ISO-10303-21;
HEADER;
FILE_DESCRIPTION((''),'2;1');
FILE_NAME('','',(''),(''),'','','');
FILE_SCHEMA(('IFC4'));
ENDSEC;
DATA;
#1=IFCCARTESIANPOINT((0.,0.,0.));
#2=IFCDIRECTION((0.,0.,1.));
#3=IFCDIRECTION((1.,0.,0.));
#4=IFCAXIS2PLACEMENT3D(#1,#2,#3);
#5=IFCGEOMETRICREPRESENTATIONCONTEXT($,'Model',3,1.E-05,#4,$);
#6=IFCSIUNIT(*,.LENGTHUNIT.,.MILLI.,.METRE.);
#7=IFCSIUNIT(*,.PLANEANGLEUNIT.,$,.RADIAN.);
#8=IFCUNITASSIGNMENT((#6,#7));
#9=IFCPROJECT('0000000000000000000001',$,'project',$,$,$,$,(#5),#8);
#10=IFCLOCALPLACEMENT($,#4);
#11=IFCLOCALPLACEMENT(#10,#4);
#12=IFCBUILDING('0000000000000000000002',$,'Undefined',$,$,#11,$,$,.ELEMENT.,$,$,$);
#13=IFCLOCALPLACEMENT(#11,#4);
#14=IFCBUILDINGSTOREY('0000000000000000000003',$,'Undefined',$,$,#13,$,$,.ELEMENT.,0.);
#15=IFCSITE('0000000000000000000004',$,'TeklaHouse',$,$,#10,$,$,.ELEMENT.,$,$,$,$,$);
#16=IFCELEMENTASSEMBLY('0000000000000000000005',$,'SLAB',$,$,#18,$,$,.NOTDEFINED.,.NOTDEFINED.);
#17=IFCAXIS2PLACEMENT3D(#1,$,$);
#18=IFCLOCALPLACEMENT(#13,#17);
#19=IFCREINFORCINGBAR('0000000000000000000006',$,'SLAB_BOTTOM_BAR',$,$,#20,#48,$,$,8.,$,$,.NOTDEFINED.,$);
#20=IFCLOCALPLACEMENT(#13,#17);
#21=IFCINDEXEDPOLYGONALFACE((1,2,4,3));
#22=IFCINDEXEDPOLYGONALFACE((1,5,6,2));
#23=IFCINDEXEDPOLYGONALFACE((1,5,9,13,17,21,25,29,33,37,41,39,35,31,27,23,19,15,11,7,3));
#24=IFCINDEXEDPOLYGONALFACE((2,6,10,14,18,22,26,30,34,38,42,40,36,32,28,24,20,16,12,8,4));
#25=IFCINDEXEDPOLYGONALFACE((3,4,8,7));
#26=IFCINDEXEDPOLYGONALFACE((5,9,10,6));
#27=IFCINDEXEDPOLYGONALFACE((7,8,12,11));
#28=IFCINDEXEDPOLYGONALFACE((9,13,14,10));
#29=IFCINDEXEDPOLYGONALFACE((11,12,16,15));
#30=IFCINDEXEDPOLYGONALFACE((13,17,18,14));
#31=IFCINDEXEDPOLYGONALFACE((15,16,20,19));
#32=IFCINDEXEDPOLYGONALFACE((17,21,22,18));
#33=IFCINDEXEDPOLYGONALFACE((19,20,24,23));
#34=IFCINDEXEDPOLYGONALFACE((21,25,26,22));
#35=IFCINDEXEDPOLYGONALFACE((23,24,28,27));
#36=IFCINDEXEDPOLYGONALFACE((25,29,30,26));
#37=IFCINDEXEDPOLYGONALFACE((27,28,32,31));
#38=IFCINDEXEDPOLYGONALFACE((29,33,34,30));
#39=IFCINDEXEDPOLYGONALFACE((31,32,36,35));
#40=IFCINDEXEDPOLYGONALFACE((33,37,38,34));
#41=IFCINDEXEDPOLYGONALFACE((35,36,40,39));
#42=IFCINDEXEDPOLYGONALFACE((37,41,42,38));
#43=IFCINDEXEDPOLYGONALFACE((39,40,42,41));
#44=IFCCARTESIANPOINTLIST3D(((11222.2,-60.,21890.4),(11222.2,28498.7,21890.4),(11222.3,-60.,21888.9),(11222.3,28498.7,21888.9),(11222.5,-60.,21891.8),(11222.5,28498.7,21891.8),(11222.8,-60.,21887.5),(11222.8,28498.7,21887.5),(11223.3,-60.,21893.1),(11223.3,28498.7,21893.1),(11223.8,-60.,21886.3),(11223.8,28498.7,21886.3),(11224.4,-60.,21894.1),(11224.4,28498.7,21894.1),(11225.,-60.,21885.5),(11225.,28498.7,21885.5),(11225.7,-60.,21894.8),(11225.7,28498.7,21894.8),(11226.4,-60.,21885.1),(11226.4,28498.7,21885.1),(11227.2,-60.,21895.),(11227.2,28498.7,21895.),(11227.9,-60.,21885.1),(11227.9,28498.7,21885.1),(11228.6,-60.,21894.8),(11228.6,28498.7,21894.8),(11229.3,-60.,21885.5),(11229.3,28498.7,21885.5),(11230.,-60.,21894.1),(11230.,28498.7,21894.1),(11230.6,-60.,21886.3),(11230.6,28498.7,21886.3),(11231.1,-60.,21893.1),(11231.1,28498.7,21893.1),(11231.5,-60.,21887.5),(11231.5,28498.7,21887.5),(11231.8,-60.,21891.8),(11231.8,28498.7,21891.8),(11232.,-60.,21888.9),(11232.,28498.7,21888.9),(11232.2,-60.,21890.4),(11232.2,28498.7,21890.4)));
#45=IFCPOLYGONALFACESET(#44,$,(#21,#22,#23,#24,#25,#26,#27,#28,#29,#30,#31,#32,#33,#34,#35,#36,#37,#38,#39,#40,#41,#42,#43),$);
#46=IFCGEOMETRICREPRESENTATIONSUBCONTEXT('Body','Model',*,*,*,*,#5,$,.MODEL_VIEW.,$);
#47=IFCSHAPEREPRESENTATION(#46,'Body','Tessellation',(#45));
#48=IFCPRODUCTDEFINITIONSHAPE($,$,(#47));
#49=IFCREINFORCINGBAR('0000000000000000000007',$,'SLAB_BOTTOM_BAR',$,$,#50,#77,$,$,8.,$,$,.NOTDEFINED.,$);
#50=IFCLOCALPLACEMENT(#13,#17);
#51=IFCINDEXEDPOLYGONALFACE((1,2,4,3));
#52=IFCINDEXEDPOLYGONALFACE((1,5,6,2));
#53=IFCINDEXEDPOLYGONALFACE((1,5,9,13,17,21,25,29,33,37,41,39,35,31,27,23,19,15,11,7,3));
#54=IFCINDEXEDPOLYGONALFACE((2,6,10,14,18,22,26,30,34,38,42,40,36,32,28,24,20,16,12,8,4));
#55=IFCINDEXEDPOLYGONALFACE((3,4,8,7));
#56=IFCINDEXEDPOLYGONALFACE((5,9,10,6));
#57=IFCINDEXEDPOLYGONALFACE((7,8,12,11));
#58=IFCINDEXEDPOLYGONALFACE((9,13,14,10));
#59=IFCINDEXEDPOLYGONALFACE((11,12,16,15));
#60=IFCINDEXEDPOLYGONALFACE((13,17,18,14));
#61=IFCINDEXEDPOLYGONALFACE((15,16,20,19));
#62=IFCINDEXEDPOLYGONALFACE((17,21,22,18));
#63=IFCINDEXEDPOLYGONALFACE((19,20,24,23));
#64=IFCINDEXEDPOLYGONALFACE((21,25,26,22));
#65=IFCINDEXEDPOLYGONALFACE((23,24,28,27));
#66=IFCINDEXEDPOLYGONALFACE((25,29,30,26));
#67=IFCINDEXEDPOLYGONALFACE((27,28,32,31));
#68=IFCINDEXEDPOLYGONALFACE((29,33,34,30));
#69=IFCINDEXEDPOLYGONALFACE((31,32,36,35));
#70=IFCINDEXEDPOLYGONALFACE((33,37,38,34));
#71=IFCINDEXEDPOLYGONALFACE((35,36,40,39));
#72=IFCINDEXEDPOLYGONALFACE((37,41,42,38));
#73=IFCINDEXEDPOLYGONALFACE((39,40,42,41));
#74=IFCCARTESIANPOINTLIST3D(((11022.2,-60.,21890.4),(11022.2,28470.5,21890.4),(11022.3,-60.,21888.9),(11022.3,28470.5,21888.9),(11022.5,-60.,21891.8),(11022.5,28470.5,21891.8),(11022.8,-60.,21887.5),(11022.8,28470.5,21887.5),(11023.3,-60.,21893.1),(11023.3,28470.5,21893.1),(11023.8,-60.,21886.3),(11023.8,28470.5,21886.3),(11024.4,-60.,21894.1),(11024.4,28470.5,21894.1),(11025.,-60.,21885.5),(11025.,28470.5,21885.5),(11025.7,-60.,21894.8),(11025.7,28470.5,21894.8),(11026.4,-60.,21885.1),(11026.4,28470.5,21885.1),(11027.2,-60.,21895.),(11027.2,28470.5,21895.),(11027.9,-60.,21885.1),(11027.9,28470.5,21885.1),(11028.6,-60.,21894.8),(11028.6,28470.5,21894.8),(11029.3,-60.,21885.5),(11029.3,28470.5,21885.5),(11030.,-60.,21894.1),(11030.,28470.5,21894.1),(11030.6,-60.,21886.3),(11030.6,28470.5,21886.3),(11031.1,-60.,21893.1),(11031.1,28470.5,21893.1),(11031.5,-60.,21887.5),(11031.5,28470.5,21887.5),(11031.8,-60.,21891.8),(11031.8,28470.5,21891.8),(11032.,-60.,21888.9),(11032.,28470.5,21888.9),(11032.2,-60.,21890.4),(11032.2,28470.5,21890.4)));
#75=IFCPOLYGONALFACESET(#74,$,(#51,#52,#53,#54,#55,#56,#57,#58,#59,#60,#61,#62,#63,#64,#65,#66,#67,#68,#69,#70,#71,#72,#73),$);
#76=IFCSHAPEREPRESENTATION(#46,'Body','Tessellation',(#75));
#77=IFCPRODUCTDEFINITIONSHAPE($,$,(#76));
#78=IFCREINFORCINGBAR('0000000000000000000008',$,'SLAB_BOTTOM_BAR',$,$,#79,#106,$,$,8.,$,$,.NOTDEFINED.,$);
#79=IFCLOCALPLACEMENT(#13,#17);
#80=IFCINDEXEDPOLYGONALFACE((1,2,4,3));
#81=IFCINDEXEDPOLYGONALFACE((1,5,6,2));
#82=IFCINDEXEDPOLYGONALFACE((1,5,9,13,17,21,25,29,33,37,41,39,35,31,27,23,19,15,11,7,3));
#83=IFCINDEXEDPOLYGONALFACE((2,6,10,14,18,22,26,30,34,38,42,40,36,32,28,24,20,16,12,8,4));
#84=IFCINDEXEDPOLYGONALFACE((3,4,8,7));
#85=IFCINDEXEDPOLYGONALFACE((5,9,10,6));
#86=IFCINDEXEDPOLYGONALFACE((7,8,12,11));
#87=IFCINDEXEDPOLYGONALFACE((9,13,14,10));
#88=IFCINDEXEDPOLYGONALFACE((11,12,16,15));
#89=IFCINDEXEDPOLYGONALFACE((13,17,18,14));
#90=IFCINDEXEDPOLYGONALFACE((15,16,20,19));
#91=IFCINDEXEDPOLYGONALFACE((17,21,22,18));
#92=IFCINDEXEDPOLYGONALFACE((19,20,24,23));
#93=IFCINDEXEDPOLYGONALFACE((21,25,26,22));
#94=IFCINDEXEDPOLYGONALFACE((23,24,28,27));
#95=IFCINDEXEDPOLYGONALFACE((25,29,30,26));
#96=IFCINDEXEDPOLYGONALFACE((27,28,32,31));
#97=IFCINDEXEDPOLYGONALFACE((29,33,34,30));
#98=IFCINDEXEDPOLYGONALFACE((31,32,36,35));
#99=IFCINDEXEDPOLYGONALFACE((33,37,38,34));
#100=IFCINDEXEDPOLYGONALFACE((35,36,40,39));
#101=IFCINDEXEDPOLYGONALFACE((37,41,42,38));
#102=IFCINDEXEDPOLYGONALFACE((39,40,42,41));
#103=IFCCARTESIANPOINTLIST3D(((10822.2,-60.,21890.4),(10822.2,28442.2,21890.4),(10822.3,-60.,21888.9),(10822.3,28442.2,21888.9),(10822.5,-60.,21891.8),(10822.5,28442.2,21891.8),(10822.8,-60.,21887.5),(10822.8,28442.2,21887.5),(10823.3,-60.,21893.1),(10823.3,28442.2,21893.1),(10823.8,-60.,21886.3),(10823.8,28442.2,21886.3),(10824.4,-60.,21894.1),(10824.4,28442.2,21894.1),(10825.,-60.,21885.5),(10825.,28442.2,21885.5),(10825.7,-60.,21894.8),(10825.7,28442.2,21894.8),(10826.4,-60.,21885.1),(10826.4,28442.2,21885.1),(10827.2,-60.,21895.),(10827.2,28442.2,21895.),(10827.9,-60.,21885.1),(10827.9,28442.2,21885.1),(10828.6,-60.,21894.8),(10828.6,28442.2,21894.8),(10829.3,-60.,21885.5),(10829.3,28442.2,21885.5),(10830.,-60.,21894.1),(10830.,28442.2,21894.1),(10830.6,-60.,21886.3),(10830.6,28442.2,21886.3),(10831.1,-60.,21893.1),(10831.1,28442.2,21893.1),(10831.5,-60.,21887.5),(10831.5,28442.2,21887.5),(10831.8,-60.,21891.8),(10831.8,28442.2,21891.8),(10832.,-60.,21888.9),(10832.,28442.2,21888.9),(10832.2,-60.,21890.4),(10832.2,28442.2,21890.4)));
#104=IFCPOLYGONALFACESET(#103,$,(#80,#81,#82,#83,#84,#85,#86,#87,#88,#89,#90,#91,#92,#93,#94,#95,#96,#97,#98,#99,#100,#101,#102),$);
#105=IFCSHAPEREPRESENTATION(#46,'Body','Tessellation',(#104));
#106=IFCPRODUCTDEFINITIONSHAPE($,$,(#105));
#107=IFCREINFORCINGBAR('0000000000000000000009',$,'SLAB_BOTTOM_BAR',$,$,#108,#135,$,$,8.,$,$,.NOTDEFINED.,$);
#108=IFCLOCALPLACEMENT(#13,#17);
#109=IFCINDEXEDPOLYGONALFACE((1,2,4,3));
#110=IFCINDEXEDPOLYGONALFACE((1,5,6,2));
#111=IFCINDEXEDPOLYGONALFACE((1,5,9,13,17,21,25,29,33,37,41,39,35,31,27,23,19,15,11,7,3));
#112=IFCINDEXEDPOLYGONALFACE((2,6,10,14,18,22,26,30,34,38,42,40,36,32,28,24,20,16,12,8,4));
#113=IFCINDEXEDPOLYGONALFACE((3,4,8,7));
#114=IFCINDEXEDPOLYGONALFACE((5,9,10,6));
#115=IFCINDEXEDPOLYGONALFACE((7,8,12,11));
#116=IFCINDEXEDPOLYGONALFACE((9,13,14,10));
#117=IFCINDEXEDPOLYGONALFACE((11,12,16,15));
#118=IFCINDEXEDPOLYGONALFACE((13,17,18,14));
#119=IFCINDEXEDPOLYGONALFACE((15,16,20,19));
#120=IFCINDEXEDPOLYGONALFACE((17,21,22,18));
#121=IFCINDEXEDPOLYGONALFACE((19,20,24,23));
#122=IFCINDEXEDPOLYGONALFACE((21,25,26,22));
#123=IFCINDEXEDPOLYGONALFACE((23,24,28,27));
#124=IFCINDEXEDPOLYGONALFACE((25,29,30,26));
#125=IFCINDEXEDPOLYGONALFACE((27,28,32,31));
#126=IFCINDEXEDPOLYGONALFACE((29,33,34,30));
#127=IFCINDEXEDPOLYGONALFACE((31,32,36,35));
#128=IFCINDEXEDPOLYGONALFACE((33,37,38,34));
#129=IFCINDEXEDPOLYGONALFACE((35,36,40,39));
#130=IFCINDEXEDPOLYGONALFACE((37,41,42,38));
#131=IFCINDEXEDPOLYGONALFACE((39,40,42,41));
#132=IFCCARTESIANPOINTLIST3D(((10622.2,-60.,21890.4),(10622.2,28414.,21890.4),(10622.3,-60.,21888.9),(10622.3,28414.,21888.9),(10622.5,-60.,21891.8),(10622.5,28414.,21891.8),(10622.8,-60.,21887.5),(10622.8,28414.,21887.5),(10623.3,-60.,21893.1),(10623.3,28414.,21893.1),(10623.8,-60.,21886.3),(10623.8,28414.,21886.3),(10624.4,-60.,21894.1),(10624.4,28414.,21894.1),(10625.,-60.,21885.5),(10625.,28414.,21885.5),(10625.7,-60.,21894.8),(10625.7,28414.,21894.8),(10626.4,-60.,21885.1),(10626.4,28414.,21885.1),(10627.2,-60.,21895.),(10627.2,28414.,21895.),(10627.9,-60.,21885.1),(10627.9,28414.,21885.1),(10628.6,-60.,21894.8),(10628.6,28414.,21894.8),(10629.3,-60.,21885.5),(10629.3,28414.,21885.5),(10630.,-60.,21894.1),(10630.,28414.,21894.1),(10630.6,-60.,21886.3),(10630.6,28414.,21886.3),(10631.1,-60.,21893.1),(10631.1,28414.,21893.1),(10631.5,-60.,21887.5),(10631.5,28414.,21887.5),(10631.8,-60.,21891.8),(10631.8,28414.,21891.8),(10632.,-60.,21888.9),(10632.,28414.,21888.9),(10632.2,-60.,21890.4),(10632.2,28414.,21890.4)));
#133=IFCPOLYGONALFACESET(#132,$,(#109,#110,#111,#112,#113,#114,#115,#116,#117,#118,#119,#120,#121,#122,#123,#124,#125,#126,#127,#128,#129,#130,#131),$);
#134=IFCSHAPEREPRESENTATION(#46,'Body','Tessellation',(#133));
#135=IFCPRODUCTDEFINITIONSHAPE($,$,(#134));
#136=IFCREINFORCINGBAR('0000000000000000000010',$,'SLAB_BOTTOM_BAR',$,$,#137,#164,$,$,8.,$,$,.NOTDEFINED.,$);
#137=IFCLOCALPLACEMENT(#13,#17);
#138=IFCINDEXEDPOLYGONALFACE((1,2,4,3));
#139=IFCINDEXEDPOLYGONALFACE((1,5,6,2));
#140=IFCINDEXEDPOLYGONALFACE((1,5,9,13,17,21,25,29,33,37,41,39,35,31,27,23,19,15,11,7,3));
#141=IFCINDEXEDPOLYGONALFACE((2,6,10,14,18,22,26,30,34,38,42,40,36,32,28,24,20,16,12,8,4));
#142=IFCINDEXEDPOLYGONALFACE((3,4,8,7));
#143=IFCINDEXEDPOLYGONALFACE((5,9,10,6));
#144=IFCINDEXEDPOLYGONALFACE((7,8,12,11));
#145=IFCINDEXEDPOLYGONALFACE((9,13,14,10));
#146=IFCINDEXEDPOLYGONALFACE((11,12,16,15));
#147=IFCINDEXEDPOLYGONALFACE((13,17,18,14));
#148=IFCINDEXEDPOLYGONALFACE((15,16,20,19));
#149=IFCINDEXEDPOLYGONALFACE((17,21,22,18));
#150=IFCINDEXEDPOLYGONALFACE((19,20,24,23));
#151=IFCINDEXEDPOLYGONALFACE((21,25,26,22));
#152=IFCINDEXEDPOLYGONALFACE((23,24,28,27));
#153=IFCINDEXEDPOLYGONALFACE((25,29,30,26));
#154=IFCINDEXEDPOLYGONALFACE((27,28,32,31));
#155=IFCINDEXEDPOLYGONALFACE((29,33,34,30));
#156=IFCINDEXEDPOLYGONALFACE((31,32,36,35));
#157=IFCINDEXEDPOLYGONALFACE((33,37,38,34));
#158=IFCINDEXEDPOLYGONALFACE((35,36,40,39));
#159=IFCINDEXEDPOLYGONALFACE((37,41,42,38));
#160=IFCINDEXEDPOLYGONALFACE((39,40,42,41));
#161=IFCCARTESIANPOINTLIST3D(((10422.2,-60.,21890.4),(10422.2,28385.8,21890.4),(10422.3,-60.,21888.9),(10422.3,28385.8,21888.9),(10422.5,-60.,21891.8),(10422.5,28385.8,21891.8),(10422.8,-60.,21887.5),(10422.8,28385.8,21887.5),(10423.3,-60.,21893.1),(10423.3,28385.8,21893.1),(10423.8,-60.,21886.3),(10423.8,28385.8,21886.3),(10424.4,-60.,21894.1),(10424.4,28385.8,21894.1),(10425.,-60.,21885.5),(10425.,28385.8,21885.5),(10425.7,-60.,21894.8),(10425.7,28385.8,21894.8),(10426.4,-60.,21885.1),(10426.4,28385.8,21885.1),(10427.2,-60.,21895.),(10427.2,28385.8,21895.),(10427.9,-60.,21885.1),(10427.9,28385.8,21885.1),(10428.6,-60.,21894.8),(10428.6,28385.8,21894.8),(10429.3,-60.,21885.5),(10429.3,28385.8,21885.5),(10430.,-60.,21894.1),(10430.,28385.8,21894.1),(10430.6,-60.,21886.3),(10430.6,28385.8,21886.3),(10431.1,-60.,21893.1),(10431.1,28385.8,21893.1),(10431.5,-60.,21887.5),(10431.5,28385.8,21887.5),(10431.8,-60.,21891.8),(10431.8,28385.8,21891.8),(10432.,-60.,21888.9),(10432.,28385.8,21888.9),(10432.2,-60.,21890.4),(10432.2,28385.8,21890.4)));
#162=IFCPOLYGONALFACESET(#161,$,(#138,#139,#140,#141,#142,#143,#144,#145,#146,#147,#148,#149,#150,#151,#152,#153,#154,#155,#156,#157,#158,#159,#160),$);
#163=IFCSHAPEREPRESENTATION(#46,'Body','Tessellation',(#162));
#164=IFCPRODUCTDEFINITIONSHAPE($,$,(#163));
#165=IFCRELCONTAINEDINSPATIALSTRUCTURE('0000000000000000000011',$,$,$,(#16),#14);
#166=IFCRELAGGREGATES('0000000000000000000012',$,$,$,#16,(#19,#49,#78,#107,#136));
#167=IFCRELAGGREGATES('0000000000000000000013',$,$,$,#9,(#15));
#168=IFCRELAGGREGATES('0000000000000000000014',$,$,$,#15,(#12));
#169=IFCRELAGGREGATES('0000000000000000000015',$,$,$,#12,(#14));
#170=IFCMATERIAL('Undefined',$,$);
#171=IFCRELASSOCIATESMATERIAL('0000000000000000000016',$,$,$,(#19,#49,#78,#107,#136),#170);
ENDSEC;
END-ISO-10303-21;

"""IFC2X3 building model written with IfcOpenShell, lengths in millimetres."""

from ifc_helpers import new_model, entity, si_unit, frame, origin_with_axes, place, context, subcontext, project, spatial, source, transform, mapped, material, element, aggregate, save


model = new_model("IFC2X3")

# Units and contexts
model_context = context("Model", 3, precision=1e-05, world=origin_with_axes())
body_context = subcontext(model_context, "Body", "Model", "MODEL_VIEW")
ifc_project = project(units=[si_unit("LENGTHUNIT", "METRE", prefix="MILLI"), si_unit("PLANEANGLEUNIT", "RADIAN")], contexts=[model_context])

# Site, building, storey
site_placement = place(None, origin_with_axes())
site = spatial("IfcSite", under=ifc_project, at=site_placement, Name="TeklaHouse", CompositionType="ELEMENT")
building_placement = place(site_placement, origin_with_axes())
building = spatial("IfcBuilding", under=site, at=building_placement, Name="Undefined", CompositionType="ELEMENT")
storey_placement = place(building_placement, origin_with_axes())
storey = spatial("IfcBuildingStorey", under=building, at=storey_placement, Name="Undefined", CompositionType="ELEMENT", Elevation=0.0)

# Shared definitions
ifc_material_1 = material(Name="Undefined")

# Element assembly, reinforcing bars
assembly_1_placement = place(storey_placement, origin_with_axes())
assembly_1 = element("IfcElementAssembly", 1, at=assembly_1_placement, inside=storey, Name="SLAB", AssemblyPlace="NOTDEFINED", PredefinedType="NOTDEFINED")
shared_shape_1 = source(origin_with_axes(), body_context, "Body", "AdvancedSweptSolid", [
    entity("IfcSweptDiskSolid", entity("IfcTrimmedCurve", entity("IfcLine", entity("IfcCartesianPoint", [0.0, 0.0, 0.0]), entity("IfcVector", entity("IfcDirection", [1.0, 0.0, 0.0]), 1.0)), [entity("IfcParameterValue", 0.0)], [entity("IfcParameterValue", 28558.731698)], True, "PARAMETER"), 5.0, None, 0.0, 28558.7),
])
reinforcing_bar_1_placement = place(assembly_1_placement, frame((11227.2, -60.0, 21890.0), z_axis=(0.0, 0.0, 1.0), x_axis=(0.0, 1.0, 0.0)))
reinforcing_bar_1 = element("IfcReinforcingBar", 2, at=reinforcing_bar_1_placement, material=ifc_material_1, Name="SLAB_BOTTOM_BAR", BarRole="NOTDEFINED", NominalDiameter=8.0, context=body_context, shape_type="MappedRepresentation", body=[
    mapped(shared_shape_1, transform((0.0, 0.0, 0.0))),
])
shared_shape_2 = source(origin_with_axes(), body_context, "Body", "AdvancedSweptSolid", [
    entity("IfcSweptDiskSolid", entity("IfcTrimmedCurve", entity("IfcLine", entity("IfcCartesianPoint", [0.0, 0.0, 0.0]), entity("IfcVector", entity("IfcDirection", [1.0, 0.0, 0.0]), 1.0)), [entity("IfcParameterValue", 0.0)], [entity("IfcParameterValue", 28530.489588)], True, "PARAMETER"), 5.0, None, 0.0, 28530.5),
])
reinforcing_bar_2_placement = place(assembly_1_placement, frame((11027.2, -60.0, 21890.0), z_axis=(0.0, 0.0, 1.0), x_axis=(0.0, 1.0, 0.0)))
reinforcing_bar_2 = element("IfcReinforcingBar", 3, at=reinforcing_bar_2_placement, material=ifc_material_1, Name="SLAB_BOTTOM_BAR", BarRole="NOTDEFINED", NominalDiameter=8.0, context=body_context, shape_type="MappedRepresentation", body=[
    mapped(shared_shape_2, transform((0.0, 0.0, 0.0))),
])
shared_shape_3 = source(origin_with_axes(), body_context, "Body", "AdvancedSweptSolid", [
    entity("IfcSweptDiskSolid", entity("IfcTrimmedCurve", entity("IfcLine", entity("IfcCartesianPoint", [0.0, 0.0, 0.0]), entity("IfcVector", entity("IfcDirection", [1.0, 0.0, 0.0]), 1.0)), [entity("IfcParameterValue", 0.0)], [entity("IfcParameterValue", 28502.247477)], True, "PARAMETER"), 5.0, None, 0.0, 28502.2),
])
reinforcing_bar_3_placement = place(assembly_1_placement, frame((10827.2, -60.0, 21890.0), z_axis=(0.0, 0.0, 1.0), x_axis=(0.0, 1.0, 0.0)))
reinforcing_bar_3 = element("IfcReinforcingBar", 4, at=reinforcing_bar_3_placement, material=ifc_material_1, Name="SLAB_BOTTOM_BAR", BarRole="NOTDEFINED", NominalDiameter=8.0, context=body_context, shape_type="MappedRepresentation", body=[
    mapped(shared_shape_3, transform((0.0, 0.0, 0.0))),
])
shared_shape_4 = source(origin_with_axes(), body_context, "Body", "AdvancedSweptSolid", [
    entity("IfcSweptDiskSolid", entity("IfcTrimmedCurve", entity("IfcLine", entity("IfcCartesianPoint", [0.0, 0.0, 0.0]), entity("IfcVector", entity("IfcDirection", [1.0, 0.0, 0.0]), 1.0)), [entity("IfcParameterValue", 0.0)], [entity("IfcParameterValue", 28474.005366)], True, "PARAMETER"), 5.0, None, 0.0, 28474.0),
])
reinforcing_bar_4_placement = place(assembly_1_placement, frame((10627.2, -60.0, 21890.0), z_axis=(0.0, 0.0, 1.0), x_axis=(0.0, 1.0, 0.0)))
reinforcing_bar_4 = element("IfcReinforcingBar", 5, at=reinforcing_bar_4_placement, material=ifc_material_1, Name="SLAB_BOTTOM_BAR", BarRole="NOTDEFINED", NominalDiameter=8.0, context=body_context, shape_type="MappedRepresentation", body=[
    mapped(shared_shape_4, transform((0.0, 0.0, 0.0))),
])
shared_shape_5 = source(origin_with_axes(), body_context, "Body", "AdvancedSweptSolid", [
    entity("IfcSweptDiskSolid", entity("IfcTrimmedCurve", entity("IfcLine", entity("IfcCartesianPoint", [0.0, 0.0, 0.0]), entity("IfcVector", entity("IfcDirection", [1.0, 0.0, 0.0]), 1.0)), [entity("IfcParameterValue", 0.0)], [entity("IfcParameterValue", 28445.763256)], True, "PARAMETER"), 5.0, None, 0.0, 28445.8),
])
reinforcing_bar_5_placement = place(assembly_1_placement, frame((10427.2, -60.0, 21890.0), z_axis=(0.0, 0.0, 1.0), x_axis=(0.0, 1.0, 0.0)))
reinforcing_bar_5 = element("IfcReinforcingBar", 6, at=reinforcing_bar_5_placement, material=ifc_material_1, Name="SLAB_BOTTOM_BAR", BarRole="NOTDEFINED", NominalDiameter=8.0, context=body_context, shape_type="MappedRepresentation", body=[
    mapped(shared_shape_5, transform((0.0, 0.0, 0.0))),
])
aggregate(assembly_1, [reinforcing_bar_1, reinforcing_bar_2, reinforcing_bar_3, reinforcing_bar_4, reinforcing_bar_5])

save(model, "model.ifc")
